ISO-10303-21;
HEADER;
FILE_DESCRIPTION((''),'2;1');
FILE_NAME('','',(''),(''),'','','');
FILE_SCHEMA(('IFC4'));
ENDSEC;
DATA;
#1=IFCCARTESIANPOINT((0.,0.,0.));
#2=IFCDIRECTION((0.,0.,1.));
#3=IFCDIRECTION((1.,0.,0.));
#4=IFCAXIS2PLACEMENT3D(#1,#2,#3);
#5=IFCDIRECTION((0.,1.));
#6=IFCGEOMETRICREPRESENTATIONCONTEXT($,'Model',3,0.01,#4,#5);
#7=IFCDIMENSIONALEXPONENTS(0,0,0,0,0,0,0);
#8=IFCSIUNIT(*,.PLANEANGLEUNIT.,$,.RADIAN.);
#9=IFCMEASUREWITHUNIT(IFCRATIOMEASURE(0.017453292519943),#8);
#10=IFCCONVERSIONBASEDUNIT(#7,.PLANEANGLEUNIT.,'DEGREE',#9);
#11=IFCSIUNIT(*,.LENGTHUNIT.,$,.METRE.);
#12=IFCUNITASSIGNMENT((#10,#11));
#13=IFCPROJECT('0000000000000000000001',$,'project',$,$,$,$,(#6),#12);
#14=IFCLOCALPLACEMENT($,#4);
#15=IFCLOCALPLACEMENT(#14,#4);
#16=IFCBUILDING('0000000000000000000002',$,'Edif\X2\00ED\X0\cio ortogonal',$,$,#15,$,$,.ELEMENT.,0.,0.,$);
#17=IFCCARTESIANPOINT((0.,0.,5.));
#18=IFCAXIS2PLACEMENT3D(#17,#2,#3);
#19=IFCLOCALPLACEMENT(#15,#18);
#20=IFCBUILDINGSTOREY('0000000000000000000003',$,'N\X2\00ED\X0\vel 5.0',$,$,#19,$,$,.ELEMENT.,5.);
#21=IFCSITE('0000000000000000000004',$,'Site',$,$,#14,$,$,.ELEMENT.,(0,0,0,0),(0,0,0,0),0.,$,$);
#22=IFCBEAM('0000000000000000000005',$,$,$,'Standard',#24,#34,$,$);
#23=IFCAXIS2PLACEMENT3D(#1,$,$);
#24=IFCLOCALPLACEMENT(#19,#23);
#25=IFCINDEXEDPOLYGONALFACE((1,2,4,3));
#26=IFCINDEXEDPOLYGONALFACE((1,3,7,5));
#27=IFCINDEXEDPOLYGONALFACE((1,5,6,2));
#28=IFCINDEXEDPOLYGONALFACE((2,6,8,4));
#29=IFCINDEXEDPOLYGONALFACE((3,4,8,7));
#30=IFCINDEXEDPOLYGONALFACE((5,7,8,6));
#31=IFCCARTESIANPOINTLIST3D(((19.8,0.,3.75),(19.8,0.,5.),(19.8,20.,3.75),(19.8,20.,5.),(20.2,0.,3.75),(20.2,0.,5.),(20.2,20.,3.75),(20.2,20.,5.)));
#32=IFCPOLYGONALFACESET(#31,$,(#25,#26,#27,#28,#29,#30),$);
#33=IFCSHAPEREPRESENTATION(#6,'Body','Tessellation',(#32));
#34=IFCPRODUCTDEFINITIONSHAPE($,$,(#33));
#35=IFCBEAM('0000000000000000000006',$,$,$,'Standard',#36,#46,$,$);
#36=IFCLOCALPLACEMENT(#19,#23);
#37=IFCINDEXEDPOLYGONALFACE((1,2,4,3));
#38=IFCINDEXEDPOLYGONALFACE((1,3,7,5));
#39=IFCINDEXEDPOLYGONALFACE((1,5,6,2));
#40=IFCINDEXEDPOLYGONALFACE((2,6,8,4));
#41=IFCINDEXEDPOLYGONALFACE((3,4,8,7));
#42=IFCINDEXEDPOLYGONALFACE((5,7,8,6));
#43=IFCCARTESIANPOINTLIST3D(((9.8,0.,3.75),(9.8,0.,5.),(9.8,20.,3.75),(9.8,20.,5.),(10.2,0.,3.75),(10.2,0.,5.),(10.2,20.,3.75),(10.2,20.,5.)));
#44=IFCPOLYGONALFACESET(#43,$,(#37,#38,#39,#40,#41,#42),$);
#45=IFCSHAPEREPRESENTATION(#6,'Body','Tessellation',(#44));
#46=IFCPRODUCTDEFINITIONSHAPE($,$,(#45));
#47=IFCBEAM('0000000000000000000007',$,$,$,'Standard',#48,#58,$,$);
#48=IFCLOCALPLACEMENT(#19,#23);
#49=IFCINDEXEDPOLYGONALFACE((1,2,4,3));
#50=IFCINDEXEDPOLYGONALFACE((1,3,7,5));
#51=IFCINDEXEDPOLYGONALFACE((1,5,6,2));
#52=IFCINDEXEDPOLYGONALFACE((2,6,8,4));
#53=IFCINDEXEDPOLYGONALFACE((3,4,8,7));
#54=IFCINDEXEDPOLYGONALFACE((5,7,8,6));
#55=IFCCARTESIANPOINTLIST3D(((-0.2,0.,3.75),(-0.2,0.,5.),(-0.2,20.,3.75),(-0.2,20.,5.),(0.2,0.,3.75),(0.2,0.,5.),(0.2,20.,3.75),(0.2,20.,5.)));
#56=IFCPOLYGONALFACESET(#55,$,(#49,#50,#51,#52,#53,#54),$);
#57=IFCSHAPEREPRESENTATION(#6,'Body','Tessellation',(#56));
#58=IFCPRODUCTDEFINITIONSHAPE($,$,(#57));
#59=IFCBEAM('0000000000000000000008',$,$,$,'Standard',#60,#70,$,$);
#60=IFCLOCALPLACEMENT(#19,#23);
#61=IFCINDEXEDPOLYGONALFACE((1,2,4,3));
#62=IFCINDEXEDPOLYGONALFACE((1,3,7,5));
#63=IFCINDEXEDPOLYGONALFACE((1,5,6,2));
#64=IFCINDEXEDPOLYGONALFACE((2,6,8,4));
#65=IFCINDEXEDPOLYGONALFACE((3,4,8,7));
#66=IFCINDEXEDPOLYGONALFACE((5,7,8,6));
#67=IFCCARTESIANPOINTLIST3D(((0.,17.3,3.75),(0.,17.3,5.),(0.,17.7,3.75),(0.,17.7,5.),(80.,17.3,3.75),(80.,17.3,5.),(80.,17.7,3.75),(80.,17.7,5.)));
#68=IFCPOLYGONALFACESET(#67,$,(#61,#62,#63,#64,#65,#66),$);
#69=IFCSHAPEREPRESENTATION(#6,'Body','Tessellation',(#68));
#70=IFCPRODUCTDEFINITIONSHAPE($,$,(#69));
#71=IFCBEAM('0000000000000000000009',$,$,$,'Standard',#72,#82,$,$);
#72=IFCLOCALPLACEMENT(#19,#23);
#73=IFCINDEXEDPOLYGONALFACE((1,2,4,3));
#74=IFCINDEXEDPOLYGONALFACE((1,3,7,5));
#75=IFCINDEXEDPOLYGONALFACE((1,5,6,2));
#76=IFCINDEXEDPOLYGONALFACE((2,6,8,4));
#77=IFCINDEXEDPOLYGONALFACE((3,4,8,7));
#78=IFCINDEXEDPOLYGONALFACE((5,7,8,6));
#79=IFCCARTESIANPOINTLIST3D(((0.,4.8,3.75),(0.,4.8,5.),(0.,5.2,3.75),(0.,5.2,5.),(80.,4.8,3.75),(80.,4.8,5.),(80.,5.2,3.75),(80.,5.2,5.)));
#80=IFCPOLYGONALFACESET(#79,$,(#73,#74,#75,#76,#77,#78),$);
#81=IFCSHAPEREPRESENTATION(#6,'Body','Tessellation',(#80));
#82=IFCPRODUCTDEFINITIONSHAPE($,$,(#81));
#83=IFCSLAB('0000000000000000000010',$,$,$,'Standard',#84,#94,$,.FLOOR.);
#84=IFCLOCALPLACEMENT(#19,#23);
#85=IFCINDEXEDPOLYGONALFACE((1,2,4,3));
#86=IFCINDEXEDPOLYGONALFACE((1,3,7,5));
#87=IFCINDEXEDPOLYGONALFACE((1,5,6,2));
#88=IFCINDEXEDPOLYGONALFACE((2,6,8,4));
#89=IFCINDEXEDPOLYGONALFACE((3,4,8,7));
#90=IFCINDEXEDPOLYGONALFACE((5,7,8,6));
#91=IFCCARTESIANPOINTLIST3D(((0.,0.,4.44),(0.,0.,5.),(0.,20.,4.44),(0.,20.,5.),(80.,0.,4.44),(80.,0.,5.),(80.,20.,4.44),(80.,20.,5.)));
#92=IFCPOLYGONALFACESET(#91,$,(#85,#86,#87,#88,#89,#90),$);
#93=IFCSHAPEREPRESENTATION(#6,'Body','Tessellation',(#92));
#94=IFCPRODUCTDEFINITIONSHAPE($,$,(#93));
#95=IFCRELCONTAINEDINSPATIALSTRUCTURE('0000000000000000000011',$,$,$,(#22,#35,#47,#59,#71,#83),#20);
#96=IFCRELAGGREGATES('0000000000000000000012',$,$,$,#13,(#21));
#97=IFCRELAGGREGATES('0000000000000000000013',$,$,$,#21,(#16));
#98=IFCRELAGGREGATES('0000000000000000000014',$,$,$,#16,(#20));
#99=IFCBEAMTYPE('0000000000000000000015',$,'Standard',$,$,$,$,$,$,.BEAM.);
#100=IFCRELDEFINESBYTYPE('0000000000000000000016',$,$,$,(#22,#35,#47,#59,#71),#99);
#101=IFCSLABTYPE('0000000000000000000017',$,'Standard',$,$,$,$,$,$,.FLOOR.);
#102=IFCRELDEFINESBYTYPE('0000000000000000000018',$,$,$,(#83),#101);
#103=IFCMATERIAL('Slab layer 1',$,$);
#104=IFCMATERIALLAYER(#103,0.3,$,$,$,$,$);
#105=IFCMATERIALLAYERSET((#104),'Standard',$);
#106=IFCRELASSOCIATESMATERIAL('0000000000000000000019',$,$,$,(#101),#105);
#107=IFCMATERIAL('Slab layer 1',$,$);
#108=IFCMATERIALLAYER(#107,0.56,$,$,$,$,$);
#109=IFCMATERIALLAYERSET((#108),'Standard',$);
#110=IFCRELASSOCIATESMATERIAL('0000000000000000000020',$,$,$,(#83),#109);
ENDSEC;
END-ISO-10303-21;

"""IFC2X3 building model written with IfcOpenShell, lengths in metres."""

from ifc_helpers import new_model, entity, si_unit, converted_unit, direction, frame, origin_with_axes, origin_2d, place, context, project, spatial, polyline, rectangle, outline, extrude, material, layer, layer_set, layer_usage, type_object, element, save


model = new_model("IFC2X3")

# Units and contexts
model_context = context("Model", 3, precision=0.01, world=origin_with_axes(), true_north=direction((0.0, 1.0)))
ifc_project = project(units=[converted_unit("PLANEANGLEUNIT", "DEGREE", entity("IfcRatioMeasure", 0.017453292519943), si_unit("PLANEANGLEUNIT", "RADIAN"), dimensions=[0, 0, 0, 0, 0, 0, 0]), si_unit("LENGTHUNIT", "METRE")], contexts=[model_context])

# Site, building, storey
site_placement = place(None, origin_with_axes())
site = spatial("IfcSite", under=ifc_project, at=site_placement, Name="Site", CompositionType="ELEMENT", RefLatitude=(0, 0, 0, 0), RefLongitude=(0, 0, 0, 0), RefElevation=0.0)
building_placement = place(site_placement, origin_with_axes())
building = spatial("IfcBuilding", under=site, at=building_placement, Name="Edifício ortogonal", CompositionType="ELEMENT", ElevationOfRefHeight=0.0, ElevationOfTerrain=0.0)
storey_placement = place(building_placement, frame((0.0, 0.0, 5.0), z_axis=(0.0, 0.0, 1.0), x_axis=(1.0, 0.0, 0.0)))
storey = spatial("IfcBuildingStorey", under=building, at=storey_placement, Name="Nível 5.0", CompositionType="ELEMENT", Elevation=5.0)

# Beams
beam_type = type_object("IfcBeamType", Name="Standard", PredefinedType="BEAM")
for number, where, z_axis, x_axis in (
    (1, (20.0, 20.0, 10.0), (0.0, 0.0, 1.0), (0.0, -1.0, 0.0)),
    (2, (10.0, 20.0, 10.0), (0.0, 0.0, 1.0), (0.0, -1.0, 0.0)),
    (3, (0.0, 20.0, 10.0), (0.0, 0.0, 1.0), (0.0, -1.0, 0.0)),
):
    element("IfcBeam", number, at=place(site_placement, frame(where, z_axis=z_axis, x_axis=x_axis)), inside=storey, type_object=beam_type, ObjectType="Standard", context=model_context, shape_type="SweptSolid", body=[
        extrude(rectangle(XDim=0.4, YDim=1.25, at=origin_2d()), frame((0.0, 0.0, -0.625), z_axis=(1.0, 0.0, 0.0), x_axis=(0.0, 1.0, 0.0)), (0.0, 0.0, 1.0), 20.0),
    ])
for number, where, z_axis, x_axis in (
    (4, (80.0, 17.5, 10.0), (0.0, 0.0, 1.0), (-1.0, 0.0, 0.0)),
    (5, (0.0, 5.0, 10.0), (0.0, 0.0, 1.0), (1.0, 0.0, 0.0)),
):
    element("IfcBeam", number, at=place(site_placement, frame(where, z_axis=z_axis, x_axis=x_axis)), inside=storey, type_object=beam_type, ObjectType="Standard", context=model_context, shape_type="SweptSolid", body=[
        extrude(rectangle(XDim=0.4, YDim=1.25, at=origin_2d()), frame((0.0, 0.0, -0.625), z_axis=(1.0, 0.0, 0.0), x_axis=(0.0, 1.0, 0.0)), (0.0, 0.0, 1.0), 80.0),
    ])

# Slab
ifc_material_1 = material(Name="Slab layer 1")
ifc_layer_1 = layer(ifc_material_1, 0.56)
ifc_layer_set_1 = layer_set([ifc_layer_1], Name="Standard")
ifc_layer_usage = layer_usage(ifc_layer_set_1, "AXIS3", "POSITIVE", 0.0)
ifc_material_2 = material(Name="Slab layer 1")
ifc_layer_2 = layer(ifc_material_2, 0.3)
ifc_layer_set_2 = layer_set([ifc_layer_2], Name="Standard")
slab_type = type_object("IfcSlabType", Name="Standard", PredefinedType="FLOOR", material=ifc_layer_set_2)
slab_placement = place(site_placement, frame((0.0, 0.0, 10.0), z_axis=(0.0, 0.0, 1.0), x_axis=(1.0, 0.0, 0.0)))
element("IfcSlab", 6, at=slab_placement, inside=storey, type_object=slab_type, material=ifc_layer_usage, ObjectType="Standard", PredefinedType="FLOOR", context=model_context, shape_type="SweptSolid", body=[
    extrude(outline(polyline([(0.0, 0.0), (80.0, 0.0), (80.0, 20.0), (0.0, 20.0), (0.0, 0.0)])), frame((0.0, 0.0, -0.56), z_axis=(0.0, 0.0, 1.0), x_axis=(1.0, 0.0, 0.0)), (0.0, 0.0, 1.0), 0.56),
])

save(model, "model.ifc")
